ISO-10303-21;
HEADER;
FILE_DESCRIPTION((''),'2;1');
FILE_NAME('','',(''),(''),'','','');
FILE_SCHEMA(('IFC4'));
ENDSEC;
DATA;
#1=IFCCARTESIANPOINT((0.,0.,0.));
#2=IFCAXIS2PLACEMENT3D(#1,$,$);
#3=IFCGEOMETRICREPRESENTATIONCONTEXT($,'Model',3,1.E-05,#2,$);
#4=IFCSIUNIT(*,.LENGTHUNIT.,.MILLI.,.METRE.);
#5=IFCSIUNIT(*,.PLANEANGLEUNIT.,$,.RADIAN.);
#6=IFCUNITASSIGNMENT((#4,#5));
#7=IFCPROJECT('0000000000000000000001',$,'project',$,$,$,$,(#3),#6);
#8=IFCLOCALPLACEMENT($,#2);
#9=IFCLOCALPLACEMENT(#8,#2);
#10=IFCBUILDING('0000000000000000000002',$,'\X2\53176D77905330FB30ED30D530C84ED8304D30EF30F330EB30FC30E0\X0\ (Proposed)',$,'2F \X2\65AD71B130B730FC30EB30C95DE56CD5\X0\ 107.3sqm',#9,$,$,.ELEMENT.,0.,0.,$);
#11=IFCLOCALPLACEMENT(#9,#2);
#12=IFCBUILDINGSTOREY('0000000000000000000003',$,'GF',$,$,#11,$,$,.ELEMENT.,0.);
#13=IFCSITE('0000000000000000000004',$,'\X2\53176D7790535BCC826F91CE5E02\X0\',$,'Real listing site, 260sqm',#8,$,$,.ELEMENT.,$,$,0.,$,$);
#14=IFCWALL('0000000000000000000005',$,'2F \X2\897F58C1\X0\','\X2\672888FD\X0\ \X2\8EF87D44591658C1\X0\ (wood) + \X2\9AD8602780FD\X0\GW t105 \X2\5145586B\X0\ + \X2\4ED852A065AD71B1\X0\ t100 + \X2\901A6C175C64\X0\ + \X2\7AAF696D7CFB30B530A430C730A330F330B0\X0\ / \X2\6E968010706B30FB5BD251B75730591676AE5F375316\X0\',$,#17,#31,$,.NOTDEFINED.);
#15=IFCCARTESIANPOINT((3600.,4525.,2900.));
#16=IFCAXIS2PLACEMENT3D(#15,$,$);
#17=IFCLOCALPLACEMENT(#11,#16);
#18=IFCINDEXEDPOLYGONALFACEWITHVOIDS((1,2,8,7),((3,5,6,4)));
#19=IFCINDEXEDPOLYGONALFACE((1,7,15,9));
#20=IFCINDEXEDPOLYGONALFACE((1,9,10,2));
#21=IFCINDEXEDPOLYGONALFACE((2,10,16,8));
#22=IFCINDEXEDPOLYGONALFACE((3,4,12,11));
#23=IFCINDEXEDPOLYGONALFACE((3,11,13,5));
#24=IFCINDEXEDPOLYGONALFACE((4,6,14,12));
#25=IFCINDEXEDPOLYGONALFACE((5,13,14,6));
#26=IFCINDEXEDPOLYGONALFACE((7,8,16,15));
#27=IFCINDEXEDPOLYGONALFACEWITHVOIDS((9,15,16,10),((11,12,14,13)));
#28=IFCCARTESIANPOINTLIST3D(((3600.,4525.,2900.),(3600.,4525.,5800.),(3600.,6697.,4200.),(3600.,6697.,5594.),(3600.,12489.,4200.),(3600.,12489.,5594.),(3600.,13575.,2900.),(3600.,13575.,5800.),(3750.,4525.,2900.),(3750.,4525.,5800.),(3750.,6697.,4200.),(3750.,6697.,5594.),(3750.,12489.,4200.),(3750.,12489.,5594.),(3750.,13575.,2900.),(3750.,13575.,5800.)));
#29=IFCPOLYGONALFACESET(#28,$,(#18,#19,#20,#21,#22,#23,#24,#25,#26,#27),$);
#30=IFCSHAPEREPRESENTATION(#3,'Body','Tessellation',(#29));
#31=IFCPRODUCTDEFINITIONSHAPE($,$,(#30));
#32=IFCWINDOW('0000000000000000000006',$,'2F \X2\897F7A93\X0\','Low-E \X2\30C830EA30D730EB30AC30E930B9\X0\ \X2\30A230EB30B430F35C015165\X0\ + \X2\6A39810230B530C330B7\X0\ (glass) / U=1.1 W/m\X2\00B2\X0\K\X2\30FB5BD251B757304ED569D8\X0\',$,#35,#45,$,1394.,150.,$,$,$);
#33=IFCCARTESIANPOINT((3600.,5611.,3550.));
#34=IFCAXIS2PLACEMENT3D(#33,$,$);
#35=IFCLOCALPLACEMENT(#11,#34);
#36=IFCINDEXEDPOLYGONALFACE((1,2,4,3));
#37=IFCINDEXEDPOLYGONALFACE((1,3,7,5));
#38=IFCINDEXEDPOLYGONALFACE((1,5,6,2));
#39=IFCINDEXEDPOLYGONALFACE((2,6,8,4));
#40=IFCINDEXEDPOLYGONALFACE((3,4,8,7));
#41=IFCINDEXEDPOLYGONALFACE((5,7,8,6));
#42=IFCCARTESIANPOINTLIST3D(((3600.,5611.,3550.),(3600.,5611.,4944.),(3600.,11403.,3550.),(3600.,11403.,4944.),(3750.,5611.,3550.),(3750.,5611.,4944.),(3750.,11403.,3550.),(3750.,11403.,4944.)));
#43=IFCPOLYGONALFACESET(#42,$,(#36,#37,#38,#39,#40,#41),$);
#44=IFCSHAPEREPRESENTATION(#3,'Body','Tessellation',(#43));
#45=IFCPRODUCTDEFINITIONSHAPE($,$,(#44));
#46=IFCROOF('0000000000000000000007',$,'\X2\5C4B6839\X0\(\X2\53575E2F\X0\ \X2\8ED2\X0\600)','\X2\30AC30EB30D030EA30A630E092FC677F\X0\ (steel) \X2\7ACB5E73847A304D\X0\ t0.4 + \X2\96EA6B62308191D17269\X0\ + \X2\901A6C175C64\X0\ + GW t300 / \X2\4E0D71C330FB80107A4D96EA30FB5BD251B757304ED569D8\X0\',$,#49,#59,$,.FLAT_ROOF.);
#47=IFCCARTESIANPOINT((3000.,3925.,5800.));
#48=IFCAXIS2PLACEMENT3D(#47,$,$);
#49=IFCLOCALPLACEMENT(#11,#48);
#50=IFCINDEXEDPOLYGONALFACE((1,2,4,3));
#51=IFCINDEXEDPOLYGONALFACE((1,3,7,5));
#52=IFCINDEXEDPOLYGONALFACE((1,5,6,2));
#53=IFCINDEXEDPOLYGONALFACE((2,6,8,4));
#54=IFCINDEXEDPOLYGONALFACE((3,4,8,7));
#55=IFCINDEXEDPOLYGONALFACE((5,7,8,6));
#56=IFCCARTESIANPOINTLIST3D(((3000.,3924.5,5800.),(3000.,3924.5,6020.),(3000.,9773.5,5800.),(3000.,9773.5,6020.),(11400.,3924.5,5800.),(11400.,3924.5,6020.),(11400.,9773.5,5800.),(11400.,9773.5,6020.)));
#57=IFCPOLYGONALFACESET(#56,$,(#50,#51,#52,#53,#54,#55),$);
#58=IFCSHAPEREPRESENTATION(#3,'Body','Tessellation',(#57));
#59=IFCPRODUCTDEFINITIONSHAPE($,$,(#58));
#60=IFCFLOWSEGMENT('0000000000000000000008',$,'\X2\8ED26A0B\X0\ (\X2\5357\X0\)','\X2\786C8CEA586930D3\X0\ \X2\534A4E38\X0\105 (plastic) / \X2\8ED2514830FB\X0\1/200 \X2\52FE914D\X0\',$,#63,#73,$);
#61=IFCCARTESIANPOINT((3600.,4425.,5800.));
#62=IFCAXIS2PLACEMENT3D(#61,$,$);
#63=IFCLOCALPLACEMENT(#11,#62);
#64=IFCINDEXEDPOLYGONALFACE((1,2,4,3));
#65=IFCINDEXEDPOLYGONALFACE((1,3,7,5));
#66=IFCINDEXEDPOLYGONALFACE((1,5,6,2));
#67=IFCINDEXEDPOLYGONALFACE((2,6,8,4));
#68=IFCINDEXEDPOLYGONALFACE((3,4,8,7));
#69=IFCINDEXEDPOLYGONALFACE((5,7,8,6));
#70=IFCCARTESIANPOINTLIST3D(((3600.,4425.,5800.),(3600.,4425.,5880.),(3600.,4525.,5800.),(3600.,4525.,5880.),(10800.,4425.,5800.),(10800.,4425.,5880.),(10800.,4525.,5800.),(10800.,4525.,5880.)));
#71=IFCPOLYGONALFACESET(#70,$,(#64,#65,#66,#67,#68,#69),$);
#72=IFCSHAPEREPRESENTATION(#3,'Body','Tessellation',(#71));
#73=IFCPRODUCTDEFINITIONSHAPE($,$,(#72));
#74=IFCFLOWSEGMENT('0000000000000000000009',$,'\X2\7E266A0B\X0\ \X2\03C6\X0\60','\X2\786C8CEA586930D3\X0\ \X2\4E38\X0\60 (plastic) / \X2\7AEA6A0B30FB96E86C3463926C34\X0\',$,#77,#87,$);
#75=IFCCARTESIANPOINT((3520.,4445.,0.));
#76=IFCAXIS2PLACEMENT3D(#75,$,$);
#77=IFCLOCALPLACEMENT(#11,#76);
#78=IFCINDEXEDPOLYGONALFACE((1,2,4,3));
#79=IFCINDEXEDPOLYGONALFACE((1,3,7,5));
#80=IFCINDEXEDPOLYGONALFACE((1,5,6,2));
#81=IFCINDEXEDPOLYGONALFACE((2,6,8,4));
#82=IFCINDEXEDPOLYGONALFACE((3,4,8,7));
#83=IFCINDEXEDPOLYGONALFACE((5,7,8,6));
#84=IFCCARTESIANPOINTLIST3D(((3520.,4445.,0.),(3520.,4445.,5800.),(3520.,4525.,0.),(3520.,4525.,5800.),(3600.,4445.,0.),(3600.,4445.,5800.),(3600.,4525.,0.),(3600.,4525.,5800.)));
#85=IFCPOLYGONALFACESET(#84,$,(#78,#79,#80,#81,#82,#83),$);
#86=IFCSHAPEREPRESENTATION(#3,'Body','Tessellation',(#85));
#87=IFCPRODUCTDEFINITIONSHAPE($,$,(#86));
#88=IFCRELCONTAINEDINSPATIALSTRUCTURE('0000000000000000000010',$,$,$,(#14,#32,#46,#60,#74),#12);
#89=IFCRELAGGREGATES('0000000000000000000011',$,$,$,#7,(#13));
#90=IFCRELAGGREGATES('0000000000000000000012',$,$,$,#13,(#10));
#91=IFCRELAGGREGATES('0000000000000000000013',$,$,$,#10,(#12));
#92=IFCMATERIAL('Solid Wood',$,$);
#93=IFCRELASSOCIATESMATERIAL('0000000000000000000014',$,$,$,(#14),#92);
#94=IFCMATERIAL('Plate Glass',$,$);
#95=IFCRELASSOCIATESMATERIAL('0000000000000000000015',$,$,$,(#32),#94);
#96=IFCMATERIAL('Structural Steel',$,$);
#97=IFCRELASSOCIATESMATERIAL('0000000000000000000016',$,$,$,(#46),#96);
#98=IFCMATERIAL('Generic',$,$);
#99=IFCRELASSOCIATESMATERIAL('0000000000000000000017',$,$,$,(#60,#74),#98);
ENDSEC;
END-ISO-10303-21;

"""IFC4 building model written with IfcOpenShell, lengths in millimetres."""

from ifc_helpers import new_model, si_unit, frame, frame_2d, origin, place, context, project, spatial, rectangle, extrude, material, element, fill, save


model = new_model("IFC4")

# Units and contexts
model_context = context("Model", 3, precision=1e-05, world=origin())
ifc_project = project(units=[si_unit("LENGTHUNIT", "METRE", prefix="MILLI"), si_unit("PLANEANGLEUNIT", "RADIAN")], contexts=[model_context])

# Site, building, storey
site_placement = place(None, origin())
site = spatial("IfcSite", under=ifc_project, at=site_placement, Name="北海道富良野市", ObjectType="Real listing site, 260sqm", CompositionType="ELEMENT", RefElevation=0.0)
building_placement = place(site_placement, origin())
building = spatial("IfcBuilding", under=site, at=building_placement, Name="北海道・ロフト付きワンルーム (Proposed)", ObjectType="2F 断熱シールド工法 107.3sqm", CompositionType="ELEMENT", ElevationOfRefHeight=0.0, ElevationOfTerrain=0.0)
storey_placement = place(building_placement, origin())
storey = spatial("IfcBuildingStorey", under=building, at=storey_placement, Name="GF", CompositionType="ELEMENT", Elevation=0.0)

# Shared definitions
ifc_material_1 = material(Name="Solid Wood")

# Shared definitions
ifc_material_2 = material(Name="Plate Glass")

# Wall, opening, window
wall_1_placement = place(storey_placement, frame((3600.0, 4525.0, 2900.0)))
wall_1 = element("IfcWall", 1, at=wall_1_placement, inside=storey, material=ifc_material_1, Name="2F 西壁", Description="木製 軸組外壁 (wood) + 高性能GW t105 充填 + 付加断熱 t100 + 通気層 + 窯業系サイディング / 準耐火・寒冷地外皮強化", PredefinedType="NOTDEFINED", context=model_context, shape_type="SweptSolid", body=[
    extrude(rectangle(XDim=150.0, YDim=9050.0, at=frame_2d((75.0, 4525.0))), frame((3600.0, 4525.0, 2900.0)), (0.0, 0.0, 1.0), 2900.0),
])
opening_1_placement = place(storey_placement, frame((3600.0, 5611.0, 3550.0)))
opening_1 = element("IfcOpeningElement", 2, at=opening_1_placement, cuts=wall_1, PredefinedType="NOTDEFINED", context=model_context, shape_type="SweptSolid", body=[
    extrude(rectangle(XDim=150.0, YDim=5792.0, at=frame_2d((75.0, 2896.0))), frame((3600.0, 5611.0, 3550.0)), (0.0, 0.0, 1.0), 1394.0),
])
window_1_placement = place(storey_placement, frame((3600.0, 5611.0, 3550.0)))
window_1 = element("IfcWindow", 3, at=window_1_placement, inside=storey, material=ifc_material_2, Name="2F 西窓", Description="Low-E トリプルガラス アルゴン封入 + 樹脂サッシ (glass) / U=1.1 W/m²K・寒冷地仕様", OverallHeight=1394.0, OverallWidth=150.0, context=model_context, shape_type="SweptSolid", body=[
    extrude(rectangle(XDim=150.0, YDim=5792.0, at=frame_2d((75.0, 2896.0))), frame((3600.0, 5611.0, 3550.0)), (0.0, 0.0, 1.0), 1394.0),
])
fill(opening_1, window_1)

# Roof
ifc_material_3 = material(Name="Structural Steel")
for number, where, name in (
    (4, (3000.0, 3925.0, 5800.0), "屋根(南帯 軒600)"),
):
    element("IfcRoof", number, at=place(storey_placement, frame(where)), inside=storey, material=ifc_material_3, Name=name, Description="ガルバリウム鋼板 (steel) 立平葺き t0.4 + 雪止め金物 + 通気層 + GW t300 / 不燃・耐積雪・寒冷地仕様", PredefinedType="FLAT_ROOF", context=model_context, shape_type="SweptSolid", body=[
        extrude(rectangle(XDim=8400.0, YDim=5849.0, at=frame_2d((4200.0, 2924.0))), frame((3000.0, 3925.0, 5800.0)), (0.0, 0.0, 1.0), 220.0),
    ])

# Flow segments
ifc_material_4 = material(Name="Generic")
flow_segment_1_placement = place(storey_placement, frame((3600.0, 4425.0, 5800.0)))
element("IfcFlowSegment", 5, at=flow_segment_1_placement, inside=storey, material=ifc_material_4, Name="軒樋 (南)", Description="硬質塩ビ 半丸105 (plastic) / 軒先・1/200 勾配", context=model_context, shape_type="SweptSolid", body=[
    extrude(rectangle(XDim=7200.0, YDim=100.0, at=frame_2d((3600.0, 50.0))), frame((3600.0, 4425.0, 5800.0)), (0.0, 0.0, 1.0), 80.0),
])
flow_segment_2_placement = place(storey_placement, frame((3520.0, 4445.0, 0.0)))
element("IfcFlowSegment", 6, at=flow_segment_2_placement, inside=storey, material=ifc_material_4, Name="縦樋 φ60", Description="硬質塩ビ 丸60 (plastic) / 竪樋・雨水排水", context=model_context, shape_type="SweptSolid", body=[
    extrude(rectangle(XDim=80.0, YDim=80.0, at=frame_2d((40.0, 40.0))), frame((3520.0, 4445.0, 0.0)), (0.0, 0.0, 1.0), 5800.0),
])

save(model, "model.ifc")
